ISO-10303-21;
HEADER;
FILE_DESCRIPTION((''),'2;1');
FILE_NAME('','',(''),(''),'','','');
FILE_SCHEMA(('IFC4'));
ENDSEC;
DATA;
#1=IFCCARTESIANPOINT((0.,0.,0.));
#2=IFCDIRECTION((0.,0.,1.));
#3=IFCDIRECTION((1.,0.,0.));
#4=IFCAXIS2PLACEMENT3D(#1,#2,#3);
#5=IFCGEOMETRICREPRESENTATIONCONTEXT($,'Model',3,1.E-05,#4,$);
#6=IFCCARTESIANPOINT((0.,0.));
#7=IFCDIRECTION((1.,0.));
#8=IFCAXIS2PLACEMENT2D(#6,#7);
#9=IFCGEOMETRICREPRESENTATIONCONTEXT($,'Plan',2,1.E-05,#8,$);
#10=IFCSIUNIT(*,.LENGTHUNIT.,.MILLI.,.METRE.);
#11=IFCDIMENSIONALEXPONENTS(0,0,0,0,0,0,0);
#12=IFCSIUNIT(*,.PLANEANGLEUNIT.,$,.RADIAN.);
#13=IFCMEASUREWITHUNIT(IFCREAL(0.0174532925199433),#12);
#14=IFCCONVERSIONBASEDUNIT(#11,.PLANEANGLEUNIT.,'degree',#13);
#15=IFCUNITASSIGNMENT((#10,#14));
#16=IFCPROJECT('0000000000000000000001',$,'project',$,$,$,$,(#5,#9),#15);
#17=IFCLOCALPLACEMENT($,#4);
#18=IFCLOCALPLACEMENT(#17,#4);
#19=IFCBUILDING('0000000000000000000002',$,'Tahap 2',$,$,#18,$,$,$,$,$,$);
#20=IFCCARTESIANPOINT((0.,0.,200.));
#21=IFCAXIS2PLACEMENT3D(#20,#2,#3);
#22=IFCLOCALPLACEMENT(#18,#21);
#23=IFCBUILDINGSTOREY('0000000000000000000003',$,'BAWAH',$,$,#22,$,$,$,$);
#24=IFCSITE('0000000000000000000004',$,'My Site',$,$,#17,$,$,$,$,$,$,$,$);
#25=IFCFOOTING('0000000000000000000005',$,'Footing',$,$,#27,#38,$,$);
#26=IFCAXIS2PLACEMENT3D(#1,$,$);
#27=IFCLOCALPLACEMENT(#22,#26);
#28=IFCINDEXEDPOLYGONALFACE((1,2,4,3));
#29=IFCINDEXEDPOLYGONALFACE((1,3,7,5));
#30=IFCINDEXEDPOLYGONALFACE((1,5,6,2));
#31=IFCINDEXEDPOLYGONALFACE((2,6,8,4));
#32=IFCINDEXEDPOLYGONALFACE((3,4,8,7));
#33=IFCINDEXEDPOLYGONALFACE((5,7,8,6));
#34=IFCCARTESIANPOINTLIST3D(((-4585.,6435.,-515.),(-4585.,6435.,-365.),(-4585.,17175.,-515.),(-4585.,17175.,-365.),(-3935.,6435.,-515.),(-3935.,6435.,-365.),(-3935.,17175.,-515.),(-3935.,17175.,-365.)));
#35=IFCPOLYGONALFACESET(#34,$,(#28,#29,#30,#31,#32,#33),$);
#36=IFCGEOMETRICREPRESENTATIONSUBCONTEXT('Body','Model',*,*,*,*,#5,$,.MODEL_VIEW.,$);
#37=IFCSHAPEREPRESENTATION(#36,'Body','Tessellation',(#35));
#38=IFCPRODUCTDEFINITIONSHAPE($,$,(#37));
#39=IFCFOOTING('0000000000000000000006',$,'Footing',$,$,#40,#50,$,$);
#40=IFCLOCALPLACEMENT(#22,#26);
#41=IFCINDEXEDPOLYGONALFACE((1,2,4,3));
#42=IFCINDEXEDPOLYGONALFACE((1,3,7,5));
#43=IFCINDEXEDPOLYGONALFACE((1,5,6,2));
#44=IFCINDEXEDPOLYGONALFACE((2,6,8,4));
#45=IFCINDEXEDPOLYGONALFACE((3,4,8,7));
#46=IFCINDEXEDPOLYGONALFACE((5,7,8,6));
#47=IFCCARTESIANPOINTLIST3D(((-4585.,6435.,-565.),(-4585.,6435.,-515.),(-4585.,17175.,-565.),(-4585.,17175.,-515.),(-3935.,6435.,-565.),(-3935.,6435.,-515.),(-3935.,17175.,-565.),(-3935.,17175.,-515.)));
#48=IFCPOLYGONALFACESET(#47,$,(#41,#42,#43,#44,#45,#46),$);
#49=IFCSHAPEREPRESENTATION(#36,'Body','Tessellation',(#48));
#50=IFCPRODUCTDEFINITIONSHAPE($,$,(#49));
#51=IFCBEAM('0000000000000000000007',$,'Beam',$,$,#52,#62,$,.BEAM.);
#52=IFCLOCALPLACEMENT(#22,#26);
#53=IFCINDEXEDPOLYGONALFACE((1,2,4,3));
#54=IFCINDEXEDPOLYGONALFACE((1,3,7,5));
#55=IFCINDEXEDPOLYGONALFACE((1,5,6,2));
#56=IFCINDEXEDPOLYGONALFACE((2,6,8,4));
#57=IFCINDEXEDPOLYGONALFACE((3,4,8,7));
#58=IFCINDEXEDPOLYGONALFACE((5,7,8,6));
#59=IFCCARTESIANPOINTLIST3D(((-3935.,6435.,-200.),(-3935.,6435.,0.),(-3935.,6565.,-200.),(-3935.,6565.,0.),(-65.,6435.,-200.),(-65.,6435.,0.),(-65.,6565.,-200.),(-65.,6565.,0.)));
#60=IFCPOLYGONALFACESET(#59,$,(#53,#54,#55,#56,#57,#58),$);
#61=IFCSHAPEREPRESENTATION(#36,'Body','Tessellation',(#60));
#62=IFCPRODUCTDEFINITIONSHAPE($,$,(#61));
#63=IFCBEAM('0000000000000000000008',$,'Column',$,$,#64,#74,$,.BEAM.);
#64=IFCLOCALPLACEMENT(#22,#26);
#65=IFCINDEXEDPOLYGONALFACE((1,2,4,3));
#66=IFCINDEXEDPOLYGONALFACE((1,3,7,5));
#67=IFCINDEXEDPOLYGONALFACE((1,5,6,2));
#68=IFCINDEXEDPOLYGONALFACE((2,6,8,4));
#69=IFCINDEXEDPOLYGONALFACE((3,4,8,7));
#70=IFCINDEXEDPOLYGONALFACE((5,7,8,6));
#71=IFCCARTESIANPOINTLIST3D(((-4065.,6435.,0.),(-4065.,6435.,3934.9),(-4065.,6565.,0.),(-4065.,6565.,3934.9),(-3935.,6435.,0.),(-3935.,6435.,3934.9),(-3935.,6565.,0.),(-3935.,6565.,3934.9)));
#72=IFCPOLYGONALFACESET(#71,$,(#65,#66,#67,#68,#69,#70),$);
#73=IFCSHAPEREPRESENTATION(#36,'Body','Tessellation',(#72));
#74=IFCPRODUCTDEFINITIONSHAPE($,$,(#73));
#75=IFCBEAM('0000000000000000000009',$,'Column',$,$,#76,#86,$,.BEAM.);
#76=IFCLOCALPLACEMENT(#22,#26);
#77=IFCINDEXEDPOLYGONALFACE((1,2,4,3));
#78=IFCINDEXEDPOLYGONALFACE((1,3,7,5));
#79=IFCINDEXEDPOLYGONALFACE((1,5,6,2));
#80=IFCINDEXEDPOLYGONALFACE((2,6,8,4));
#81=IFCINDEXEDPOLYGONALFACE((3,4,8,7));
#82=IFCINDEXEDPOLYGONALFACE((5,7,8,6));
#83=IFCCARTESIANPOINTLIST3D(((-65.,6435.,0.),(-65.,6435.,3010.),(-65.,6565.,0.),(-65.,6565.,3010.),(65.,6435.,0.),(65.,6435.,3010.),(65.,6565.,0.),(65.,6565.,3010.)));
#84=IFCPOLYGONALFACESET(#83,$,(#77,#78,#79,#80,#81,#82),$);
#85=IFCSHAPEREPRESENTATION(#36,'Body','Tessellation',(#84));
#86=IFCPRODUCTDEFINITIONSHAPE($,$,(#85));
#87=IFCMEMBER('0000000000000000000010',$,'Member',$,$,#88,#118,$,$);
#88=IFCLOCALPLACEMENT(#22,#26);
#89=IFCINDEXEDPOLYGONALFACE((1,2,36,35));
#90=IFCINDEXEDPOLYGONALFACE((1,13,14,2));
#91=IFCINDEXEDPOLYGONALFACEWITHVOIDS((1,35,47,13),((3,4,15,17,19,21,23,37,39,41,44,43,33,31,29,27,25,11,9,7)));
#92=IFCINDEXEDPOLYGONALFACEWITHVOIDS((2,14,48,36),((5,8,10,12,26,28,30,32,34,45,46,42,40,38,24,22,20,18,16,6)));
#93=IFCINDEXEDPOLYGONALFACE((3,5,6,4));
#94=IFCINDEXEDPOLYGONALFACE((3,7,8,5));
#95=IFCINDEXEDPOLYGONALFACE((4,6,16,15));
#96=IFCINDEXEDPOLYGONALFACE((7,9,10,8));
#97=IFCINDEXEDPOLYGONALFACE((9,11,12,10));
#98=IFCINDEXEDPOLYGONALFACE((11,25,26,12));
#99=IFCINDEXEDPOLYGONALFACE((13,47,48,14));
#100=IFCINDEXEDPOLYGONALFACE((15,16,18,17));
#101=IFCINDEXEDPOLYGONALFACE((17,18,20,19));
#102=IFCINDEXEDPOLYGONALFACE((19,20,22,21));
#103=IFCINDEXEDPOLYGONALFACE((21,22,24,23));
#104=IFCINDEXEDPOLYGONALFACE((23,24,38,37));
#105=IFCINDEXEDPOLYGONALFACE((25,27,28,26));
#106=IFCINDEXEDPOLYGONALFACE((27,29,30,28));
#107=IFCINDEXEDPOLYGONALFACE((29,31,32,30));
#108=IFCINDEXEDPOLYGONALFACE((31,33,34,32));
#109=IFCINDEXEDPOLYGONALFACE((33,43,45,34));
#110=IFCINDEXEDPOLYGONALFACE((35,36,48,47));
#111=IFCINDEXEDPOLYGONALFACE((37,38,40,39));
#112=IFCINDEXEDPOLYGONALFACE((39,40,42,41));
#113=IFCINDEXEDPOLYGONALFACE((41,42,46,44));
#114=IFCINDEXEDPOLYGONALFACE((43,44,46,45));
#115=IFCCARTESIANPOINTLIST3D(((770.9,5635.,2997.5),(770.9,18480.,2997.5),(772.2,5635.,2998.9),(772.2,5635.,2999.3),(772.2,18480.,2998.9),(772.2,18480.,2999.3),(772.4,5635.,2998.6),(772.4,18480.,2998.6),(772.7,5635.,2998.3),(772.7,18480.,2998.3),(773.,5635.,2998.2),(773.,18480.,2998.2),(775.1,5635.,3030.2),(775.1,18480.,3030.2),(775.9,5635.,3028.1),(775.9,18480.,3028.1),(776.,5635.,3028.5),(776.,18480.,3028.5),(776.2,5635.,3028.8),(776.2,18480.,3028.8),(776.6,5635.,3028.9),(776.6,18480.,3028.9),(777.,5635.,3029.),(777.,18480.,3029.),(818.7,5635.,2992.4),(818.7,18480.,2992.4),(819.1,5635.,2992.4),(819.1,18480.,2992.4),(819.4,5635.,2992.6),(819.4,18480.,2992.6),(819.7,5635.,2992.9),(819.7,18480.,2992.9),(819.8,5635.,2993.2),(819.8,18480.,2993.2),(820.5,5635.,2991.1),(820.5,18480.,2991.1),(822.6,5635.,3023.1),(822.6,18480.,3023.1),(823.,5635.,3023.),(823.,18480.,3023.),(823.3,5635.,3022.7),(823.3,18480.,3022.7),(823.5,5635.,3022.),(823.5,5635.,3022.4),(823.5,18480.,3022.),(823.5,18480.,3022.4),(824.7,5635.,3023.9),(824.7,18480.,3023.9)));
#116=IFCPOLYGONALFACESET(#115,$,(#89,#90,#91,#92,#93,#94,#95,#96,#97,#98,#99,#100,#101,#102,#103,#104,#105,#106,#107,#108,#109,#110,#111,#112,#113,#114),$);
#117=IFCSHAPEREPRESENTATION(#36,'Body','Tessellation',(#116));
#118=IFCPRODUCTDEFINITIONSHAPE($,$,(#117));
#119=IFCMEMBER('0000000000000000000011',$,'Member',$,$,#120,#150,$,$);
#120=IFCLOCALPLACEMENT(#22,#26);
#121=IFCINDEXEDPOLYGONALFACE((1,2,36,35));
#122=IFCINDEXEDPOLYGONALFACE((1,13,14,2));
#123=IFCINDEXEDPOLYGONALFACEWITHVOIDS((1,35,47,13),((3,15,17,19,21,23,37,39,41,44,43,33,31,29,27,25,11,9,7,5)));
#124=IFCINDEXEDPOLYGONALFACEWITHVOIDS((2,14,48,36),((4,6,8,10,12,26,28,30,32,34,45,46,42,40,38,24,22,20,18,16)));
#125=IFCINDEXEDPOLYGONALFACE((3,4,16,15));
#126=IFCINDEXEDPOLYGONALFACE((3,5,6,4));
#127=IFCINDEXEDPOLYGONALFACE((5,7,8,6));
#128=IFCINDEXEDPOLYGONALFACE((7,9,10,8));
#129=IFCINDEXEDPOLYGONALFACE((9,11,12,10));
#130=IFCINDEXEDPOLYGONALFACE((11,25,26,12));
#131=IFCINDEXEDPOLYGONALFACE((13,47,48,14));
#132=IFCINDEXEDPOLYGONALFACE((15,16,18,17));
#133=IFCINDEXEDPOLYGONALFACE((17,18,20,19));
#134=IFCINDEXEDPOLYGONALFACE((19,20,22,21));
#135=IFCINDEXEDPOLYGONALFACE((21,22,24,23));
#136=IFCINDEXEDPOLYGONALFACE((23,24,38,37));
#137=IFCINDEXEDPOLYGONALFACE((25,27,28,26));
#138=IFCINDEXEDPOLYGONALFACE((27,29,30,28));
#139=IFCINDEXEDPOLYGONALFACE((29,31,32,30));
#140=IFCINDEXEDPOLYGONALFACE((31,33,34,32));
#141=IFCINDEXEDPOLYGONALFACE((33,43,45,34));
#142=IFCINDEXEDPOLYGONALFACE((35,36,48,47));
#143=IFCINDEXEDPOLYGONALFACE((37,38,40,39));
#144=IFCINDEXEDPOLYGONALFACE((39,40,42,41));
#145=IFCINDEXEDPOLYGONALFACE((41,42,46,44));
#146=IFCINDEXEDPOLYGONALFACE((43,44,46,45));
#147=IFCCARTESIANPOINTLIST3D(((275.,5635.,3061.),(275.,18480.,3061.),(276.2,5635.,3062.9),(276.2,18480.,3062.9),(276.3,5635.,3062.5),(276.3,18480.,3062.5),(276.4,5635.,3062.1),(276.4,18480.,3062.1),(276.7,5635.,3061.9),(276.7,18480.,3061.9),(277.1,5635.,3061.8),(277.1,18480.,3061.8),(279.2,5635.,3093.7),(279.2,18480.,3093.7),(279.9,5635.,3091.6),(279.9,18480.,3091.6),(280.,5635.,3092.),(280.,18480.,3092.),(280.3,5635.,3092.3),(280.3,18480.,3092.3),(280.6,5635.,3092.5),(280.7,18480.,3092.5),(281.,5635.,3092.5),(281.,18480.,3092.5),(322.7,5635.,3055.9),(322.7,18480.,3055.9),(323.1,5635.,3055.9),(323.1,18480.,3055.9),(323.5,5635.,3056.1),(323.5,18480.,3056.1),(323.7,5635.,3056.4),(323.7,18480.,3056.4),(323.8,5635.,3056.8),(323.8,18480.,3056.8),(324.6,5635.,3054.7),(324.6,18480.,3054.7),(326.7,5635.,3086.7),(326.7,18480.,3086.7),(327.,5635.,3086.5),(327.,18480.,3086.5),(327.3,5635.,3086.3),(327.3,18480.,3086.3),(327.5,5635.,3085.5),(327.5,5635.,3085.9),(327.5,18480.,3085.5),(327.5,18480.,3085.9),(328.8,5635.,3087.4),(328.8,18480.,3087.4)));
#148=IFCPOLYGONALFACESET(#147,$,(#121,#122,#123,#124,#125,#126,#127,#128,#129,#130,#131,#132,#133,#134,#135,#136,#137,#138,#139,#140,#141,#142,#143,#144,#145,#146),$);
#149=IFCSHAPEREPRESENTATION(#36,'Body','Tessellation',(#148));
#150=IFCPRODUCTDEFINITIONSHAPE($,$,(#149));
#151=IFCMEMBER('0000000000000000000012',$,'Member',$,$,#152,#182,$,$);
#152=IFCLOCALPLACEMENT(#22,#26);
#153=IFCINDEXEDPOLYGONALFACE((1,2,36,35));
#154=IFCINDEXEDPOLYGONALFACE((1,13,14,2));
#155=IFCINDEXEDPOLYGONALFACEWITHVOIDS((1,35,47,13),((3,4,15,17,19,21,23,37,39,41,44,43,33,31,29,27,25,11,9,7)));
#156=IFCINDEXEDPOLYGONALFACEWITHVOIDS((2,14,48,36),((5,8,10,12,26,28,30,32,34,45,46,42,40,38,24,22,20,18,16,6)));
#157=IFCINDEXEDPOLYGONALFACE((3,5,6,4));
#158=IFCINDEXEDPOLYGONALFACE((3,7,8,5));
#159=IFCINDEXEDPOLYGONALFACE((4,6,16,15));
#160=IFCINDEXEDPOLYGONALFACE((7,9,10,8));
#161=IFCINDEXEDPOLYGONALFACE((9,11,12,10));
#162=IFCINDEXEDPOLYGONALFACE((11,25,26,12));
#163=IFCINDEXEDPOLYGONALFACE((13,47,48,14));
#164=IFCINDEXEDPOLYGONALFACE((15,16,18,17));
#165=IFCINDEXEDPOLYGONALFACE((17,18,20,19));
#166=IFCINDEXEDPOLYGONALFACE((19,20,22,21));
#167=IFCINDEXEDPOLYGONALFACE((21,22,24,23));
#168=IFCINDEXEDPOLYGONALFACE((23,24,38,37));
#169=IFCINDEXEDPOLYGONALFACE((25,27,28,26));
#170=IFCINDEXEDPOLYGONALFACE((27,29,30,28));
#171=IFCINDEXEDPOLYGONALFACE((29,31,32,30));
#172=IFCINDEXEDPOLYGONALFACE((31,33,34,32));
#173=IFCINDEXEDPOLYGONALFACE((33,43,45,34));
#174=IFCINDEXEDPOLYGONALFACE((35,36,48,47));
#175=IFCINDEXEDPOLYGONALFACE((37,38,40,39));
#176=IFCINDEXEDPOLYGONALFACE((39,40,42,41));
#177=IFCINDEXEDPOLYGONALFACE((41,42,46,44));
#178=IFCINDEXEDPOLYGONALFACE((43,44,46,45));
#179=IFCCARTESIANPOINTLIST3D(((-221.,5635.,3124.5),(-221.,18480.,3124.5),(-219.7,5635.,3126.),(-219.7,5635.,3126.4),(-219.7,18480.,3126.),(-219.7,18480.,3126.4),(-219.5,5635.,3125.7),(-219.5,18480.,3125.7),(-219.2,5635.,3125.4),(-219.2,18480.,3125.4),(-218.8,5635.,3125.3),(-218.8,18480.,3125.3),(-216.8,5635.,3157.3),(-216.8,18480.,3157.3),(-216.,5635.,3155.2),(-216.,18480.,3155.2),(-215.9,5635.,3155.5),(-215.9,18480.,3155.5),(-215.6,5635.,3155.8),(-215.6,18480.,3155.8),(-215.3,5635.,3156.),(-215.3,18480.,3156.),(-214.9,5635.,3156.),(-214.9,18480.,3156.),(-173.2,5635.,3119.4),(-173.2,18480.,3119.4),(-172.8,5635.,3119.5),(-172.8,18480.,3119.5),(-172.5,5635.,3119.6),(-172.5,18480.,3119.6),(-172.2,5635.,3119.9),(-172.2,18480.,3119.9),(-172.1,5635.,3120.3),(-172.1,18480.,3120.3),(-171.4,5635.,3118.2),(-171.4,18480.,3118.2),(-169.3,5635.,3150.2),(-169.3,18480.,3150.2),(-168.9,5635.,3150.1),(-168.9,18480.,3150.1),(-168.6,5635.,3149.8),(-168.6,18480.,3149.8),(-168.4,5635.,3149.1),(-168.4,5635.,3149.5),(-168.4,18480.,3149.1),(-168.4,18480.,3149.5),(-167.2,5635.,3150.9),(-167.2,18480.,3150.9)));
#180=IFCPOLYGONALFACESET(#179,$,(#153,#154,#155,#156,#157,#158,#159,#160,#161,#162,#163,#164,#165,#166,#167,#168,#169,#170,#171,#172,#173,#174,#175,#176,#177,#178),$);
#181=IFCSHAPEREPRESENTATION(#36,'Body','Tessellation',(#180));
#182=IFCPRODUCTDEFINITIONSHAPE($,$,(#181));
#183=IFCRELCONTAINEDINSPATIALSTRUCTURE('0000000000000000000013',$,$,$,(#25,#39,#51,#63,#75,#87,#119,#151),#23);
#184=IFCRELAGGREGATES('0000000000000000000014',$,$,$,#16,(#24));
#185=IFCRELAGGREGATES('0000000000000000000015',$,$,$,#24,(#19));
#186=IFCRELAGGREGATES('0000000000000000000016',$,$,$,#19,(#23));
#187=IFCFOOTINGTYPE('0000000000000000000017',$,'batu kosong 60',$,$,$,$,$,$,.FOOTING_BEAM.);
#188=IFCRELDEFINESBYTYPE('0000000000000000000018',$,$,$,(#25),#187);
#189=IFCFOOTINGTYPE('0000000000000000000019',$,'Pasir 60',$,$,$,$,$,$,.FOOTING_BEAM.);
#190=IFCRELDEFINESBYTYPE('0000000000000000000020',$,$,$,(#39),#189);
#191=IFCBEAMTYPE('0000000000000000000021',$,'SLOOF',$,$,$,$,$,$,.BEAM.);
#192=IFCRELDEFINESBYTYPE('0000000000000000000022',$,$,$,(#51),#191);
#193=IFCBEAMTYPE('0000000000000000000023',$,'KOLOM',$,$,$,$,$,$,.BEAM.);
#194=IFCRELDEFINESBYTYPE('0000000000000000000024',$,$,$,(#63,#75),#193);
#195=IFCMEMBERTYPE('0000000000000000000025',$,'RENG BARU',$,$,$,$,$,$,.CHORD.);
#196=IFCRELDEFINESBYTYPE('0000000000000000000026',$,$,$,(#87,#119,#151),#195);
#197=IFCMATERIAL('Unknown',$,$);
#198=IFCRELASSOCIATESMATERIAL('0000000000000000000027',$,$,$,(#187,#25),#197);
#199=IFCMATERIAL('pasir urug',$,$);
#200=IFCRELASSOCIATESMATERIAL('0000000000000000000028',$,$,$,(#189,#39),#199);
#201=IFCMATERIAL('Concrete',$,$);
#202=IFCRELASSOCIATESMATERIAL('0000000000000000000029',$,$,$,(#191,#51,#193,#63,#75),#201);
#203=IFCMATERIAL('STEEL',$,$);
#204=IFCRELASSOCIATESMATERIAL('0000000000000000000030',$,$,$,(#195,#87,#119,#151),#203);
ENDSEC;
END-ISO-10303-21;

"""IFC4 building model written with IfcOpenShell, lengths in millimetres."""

from ifc_helpers import new_model, entity, si_unit, converted_unit, frame, origin_with_axes, origin_2d_with_axis, place, context, subcontext, project, spatial, indexed_curve, rectangle, hollow_rectangle, outline, extrude, material, material_profile, profile_set, profile_usage, type_object, element, save


model = new_model("IFC4")

# Units and contexts
model_context = context("Model", 3, precision=1e-05, world=origin_with_axes())
plan_context = context("Plan", 2, precision=1e-05, world=origin_2d_with_axis())
body_context = subcontext(model_context, "Body", "Model", "MODEL_VIEW")
ifc_project = project(units=[si_unit("LENGTHUNIT", "METRE", prefix="MILLI"), converted_unit("PLANEANGLEUNIT", "degree", entity("IfcReal", 0.0174532925199433), si_unit("PLANEANGLEUNIT", "RADIAN"), dimensions=[0, 0, 0, 0, 0, 0, 0])], contexts=[model_context, plan_context])

# Site, building, storey
site_placement = place(None, origin_with_axes())
site = spatial("IfcSite", under=ifc_project, at=site_placement, Name="My Site")
building_placement = place(site_placement, origin_with_axes())
building = spatial("IfcBuilding", under=site, at=building_placement, Name="Tahap 2")
storey_placement = place(building_placement, frame((0.0, 0.0, 200.0), z_axis=(0.0, 0.0, 1.0), x_axis=(1.0, 0.0, 0.0)))
storey = spatial("IfcBuildingStorey", under=building, at=storey_placement, Name="BAWAH")

# Footings
ifc_material_1 = material(Name="Unknown")
ifc_material_profile_1 = material_profile(ifc_material_1, rectangle(XDim=650.0, YDim=150.0, kind="CURVE"))
ifc_profile_set_1 = profile_set([ifc_material_profile_1])
ifc_profile_usage_1 = profile_usage(ifc_profile_set_1, cardinal=9)
footing_type_1 = type_object("IfcFootingType", Name="batu kosong 60", PredefinedType="FOOTING_BEAM", material=ifc_profile_set_1)
footing_1_placement = place(storey_placement, frame((-3935.0, 6435.0, -365.0), z_axis=(0.0, 1.0, 0.0), x_axis=(-1.0, 0.0, 0.0)))
element("IfcFooting", 1, at=footing_1_placement, inside=storey, type_object=footing_type_1, material=ifc_profile_usage_1, Name="Footing", context=body_context, shape_type="SweptSolid", body=[
    extrude(rectangle(XDim=650.0, YDim=150.0, kind="CURVE"), frame((325.0, -75.0, 0.0), z_axis=(0.0, 0.0, 1.0), x_axis=(1.0, 0.0, 0.0)), (0.0, 0.0, 1.0), 10740.0),
])
ifc_material_2 = material(Name="pasir urug")
ifc_material_profile_2 = material_profile(ifc_material_2, rectangle(XDim=650.0, YDim=50.0, kind="CURVE"))
ifc_profile_set_2 = profile_set([ifc_material_profile_2])
ifc_profile_usage_2 = profile_usage(ifc_profile_set_2, cardinal=8)
footing_type_2 = type_object("IfcFootingType", Name="Pasir 60", PredefinedType="FOOTING_BEAM", material=ifc_profile_set_2)
footing_2_placement = place(storey_placement, frame((-4260.0, 6435.0, -515.0), z_axis=(0.0, 1.0, 0.0), x_axis=(-1.0, 0.0, 0.0)))
element("IfcFooting", 2, at=footing_2_placement, inside=storey, type_object=footing_type_2, material=ifc_profile_usage_2, Name="Footing", context=body_context, shape_type="SweptSolid", body=[
    extrude(rectangle(XDim=650.0, YDim=50.0, kind="CURVE"), frame((0.0, -25.0, 0.0), z_axis=(0.0, 0.0, 1.0), x_axis=(1.0, 0.0, 0.0)), (0.0, 0.0, 1.0), 10740.0),
])

# Beams
ifc_material_3 = material(Name="Concrete")
ifc_material_profile_3 = material_profile(ifc_material_3, outline(indexed_curve([(-65.0, 100.0), (65.0, 100.0), (65.0, -100.0), (-65.0, -100.0), (-65.0, 100.0)])))
ifc_profile_set_3 = profile_set([ifc_material_profile_3])
ifc_profile_usage_3 = profile_usage(ifc_profile_set_3, cardinal=2)
beam_type_1 = type_object("IfcBeamType", Name="SLOOF", PredefinedType="BEAM", material=ifc_profile_set_3)
beam_1_placement = place(storey_placement, frame((-3935.0, 6500.0, -200.0), z_axis=(1.0, 0.0, 0.000001), x_axis=(0.0, 1.0, 0.0)))
element("IfcBeam", 3, at=beam_1_placement, inside=storey, type_object=beam_type_1, material=ifc_profile_usage_3, Name="Beam", PredefinedType="BEAM", context=body_context, shape_type="SweptSolid", body=[
    extrude(outline(indexed_curve([(-65.0, 100.0), (65.0, 100.0), (65.0, -100.0), (-65.0, -100.0), (-65.0, 100.0)])), frame((0.0, 100.0, 0.0), z_axis=(0.0, 0.0, 1.0), x_axis=(1.0, 0.0, 0.0)), (0.0, 0.0, 1.0), 3870.0),
])
ifc_material_profile_4 = material_profile(ifc_material_3, rectangle(XDim=130.0, YDim=130.0, kind="CURVE"))
ifc_profile_set_4 = profile_set([ifc_material_profile_4])
ifc_profile_usage_4 = profile_usage(ifc_profile_set_4, cardinal=5)
beam_type_2 = type_object("IfcBeamType", Name="KOLOM", PredefinedType="BEAM", material=ifc_profile_set_4)
beam_2_placement = place(storey_placement, frame((-4000.0, 6500.0, 0.0), z_axis=(0.0, 0.0, 1.0), x_axis=(1.0, 0.0, 0.0)))
element("IfcBeam", 4, at=beam_2_placement, inside=storey, type_object=beam_type_2, material=ifc_profile_usage_4, Name="Column", PredefinedType="BEAM", context=body_context, shape_type="SweptSolid", body=[
    extrude(rectangle(XDim=130.0, YDim=130.0, kind="CURVE"), origin_with_axes(), (0.0, 0.0, 1.0), 3934.9),
])
ifc_profile_usage_5 = profile_usage(ifc_profile_set_4, cardinal=2)
beam_3_placement = place(storey_placement, frame((0.0, 6435.0, 0.0), z_axis=(0.0, 0.0, 1.0), x_axis=(1.0, 0.0, 0.0)))
element("IfcBeam", 5, at=beam_3_placement, inside=storey, type_object=beam_type_2, material=ifc_profile_usage_5, Name="Column", PredefinedType="BEAM", context=body_context, shape_type="SweptSolid", body=[
    extrude(rectangle(XDim=130.0, YDim=130.0, kind="CURVE"), frame((0.0, 65.0, 0.0), z_axis=(0.0, 0.0, 1.0), x_axis=(1.0, 0.0, 0.0)), (0.0, 0.0, 1.0), 3010.0),
])

# Shared definitions
ifc_material_4 = material(Name="STEEL")

# Members
ifc_material_profile_5 = material_profile(ifc_material_4, hollow_rectangle(XDim=50.0, YDim=33.0, WallThickness=1.0, InnerFilletRadius=1.0, OuterFilletRadius=0.0, kind="CURVE"))
ifc_profile_set_5 = profile_set([ifc_material_profile_5])
ifc_profile_usage_6 = profile_usage(ifc_profile_set_5, cardinal=3)
member_type_1 = type_object("IfcMemberType", Name="RENG BARU", PredefinedType="CHORD", material=ifc_profile_set_5)
member_1_placement = place(storey_placement, frame((820.5, 5635.0, 2991.1), z_axis=(0.0, 1.0, 0.0), x_axis=(-0.991894, 0.0, 0.127065)))
element("IfcMember", 6, at=member_1_placement, inside=storey, type_object=member_type_1, material=ifc_profile_usage_6, Name="Member", context=body_context, shape_type="SweptSolid", body=[
    extrude(hollow_rectangle(XDim=50.0, YDim=33.0, WallThickness=1.0, InnerFilletRadius=1.0, OuterFilletRadius=0.0, kind="CURVE"), frame((25.0, 16.5, 0.0), z_axis=(0.0, 0.0, 1.0), x_axis=(1.0, 0.0, 0.0)), (0.0, 0.0, 1.0), 12845.0),
])
ifc_profile_usage_7 = profile_usage(ifc_profile_set_5, cardinal=3)
member_2_placement = place(storey_placement, frame((324.6, 5635.0, 3054.7), z_axis=(0.0, 1.0, 0.0), x_axis=(-0.991894, 0.0, 0.127065)))
element("IfcMember", 7, at=member_2_placement, inside=storey, type_object=member_type_1, material=ifc_profile_usage_7, Name="Member", context=body_context, shape_type="SweptSolid", body=[
    extrude(hollow_rectangle(XDim=50.0, YDim=33.0, WallThickness=1.0, InnerFilletRadius=1.0, OuterFilletRadius=0.0, kind="CURVE"), frame((25.0, 16.5, 0.0), z_axis=(0.0, 0.0, 1.0), x_axis=(1.0, 0.0, 0.0)), (0.0, 0.0, 1.0), 12845.0),
])
ifc_profile_usage_8 = profile_usage(ifc_profile_set_5, cardinal=3)
member_3_placement = place(storey_placement, frame((-171.4, 5635.0, 3118.2), z_axis=(0.0, 1.0, 0.0), x_axis=(-0.991894, 0.0, 0.127065)))
element("IfcMember", 8, at=member_3_placement, inside=storey, type_object=member_type_1, material=ifc_profile_usage_8, Name="Member", context=body_context, shape_type="SweptSolid", body=[
    extrude(hollow_rectangle(XDim=50.0, YDim=33.0, WallThickness=1.0, InnerFilletRadius=1.0, OuterFilletRadius=0.0, kind="CURVE"), frame((25.0, 16.5, 0.0), z_axis=(0.0, 0.0, 1.0), x_axis=(1.0, 0.0, 0.0)), (0.0, 0.0, 1.0), 12845.0),
])

save(model, "model.ifc")
